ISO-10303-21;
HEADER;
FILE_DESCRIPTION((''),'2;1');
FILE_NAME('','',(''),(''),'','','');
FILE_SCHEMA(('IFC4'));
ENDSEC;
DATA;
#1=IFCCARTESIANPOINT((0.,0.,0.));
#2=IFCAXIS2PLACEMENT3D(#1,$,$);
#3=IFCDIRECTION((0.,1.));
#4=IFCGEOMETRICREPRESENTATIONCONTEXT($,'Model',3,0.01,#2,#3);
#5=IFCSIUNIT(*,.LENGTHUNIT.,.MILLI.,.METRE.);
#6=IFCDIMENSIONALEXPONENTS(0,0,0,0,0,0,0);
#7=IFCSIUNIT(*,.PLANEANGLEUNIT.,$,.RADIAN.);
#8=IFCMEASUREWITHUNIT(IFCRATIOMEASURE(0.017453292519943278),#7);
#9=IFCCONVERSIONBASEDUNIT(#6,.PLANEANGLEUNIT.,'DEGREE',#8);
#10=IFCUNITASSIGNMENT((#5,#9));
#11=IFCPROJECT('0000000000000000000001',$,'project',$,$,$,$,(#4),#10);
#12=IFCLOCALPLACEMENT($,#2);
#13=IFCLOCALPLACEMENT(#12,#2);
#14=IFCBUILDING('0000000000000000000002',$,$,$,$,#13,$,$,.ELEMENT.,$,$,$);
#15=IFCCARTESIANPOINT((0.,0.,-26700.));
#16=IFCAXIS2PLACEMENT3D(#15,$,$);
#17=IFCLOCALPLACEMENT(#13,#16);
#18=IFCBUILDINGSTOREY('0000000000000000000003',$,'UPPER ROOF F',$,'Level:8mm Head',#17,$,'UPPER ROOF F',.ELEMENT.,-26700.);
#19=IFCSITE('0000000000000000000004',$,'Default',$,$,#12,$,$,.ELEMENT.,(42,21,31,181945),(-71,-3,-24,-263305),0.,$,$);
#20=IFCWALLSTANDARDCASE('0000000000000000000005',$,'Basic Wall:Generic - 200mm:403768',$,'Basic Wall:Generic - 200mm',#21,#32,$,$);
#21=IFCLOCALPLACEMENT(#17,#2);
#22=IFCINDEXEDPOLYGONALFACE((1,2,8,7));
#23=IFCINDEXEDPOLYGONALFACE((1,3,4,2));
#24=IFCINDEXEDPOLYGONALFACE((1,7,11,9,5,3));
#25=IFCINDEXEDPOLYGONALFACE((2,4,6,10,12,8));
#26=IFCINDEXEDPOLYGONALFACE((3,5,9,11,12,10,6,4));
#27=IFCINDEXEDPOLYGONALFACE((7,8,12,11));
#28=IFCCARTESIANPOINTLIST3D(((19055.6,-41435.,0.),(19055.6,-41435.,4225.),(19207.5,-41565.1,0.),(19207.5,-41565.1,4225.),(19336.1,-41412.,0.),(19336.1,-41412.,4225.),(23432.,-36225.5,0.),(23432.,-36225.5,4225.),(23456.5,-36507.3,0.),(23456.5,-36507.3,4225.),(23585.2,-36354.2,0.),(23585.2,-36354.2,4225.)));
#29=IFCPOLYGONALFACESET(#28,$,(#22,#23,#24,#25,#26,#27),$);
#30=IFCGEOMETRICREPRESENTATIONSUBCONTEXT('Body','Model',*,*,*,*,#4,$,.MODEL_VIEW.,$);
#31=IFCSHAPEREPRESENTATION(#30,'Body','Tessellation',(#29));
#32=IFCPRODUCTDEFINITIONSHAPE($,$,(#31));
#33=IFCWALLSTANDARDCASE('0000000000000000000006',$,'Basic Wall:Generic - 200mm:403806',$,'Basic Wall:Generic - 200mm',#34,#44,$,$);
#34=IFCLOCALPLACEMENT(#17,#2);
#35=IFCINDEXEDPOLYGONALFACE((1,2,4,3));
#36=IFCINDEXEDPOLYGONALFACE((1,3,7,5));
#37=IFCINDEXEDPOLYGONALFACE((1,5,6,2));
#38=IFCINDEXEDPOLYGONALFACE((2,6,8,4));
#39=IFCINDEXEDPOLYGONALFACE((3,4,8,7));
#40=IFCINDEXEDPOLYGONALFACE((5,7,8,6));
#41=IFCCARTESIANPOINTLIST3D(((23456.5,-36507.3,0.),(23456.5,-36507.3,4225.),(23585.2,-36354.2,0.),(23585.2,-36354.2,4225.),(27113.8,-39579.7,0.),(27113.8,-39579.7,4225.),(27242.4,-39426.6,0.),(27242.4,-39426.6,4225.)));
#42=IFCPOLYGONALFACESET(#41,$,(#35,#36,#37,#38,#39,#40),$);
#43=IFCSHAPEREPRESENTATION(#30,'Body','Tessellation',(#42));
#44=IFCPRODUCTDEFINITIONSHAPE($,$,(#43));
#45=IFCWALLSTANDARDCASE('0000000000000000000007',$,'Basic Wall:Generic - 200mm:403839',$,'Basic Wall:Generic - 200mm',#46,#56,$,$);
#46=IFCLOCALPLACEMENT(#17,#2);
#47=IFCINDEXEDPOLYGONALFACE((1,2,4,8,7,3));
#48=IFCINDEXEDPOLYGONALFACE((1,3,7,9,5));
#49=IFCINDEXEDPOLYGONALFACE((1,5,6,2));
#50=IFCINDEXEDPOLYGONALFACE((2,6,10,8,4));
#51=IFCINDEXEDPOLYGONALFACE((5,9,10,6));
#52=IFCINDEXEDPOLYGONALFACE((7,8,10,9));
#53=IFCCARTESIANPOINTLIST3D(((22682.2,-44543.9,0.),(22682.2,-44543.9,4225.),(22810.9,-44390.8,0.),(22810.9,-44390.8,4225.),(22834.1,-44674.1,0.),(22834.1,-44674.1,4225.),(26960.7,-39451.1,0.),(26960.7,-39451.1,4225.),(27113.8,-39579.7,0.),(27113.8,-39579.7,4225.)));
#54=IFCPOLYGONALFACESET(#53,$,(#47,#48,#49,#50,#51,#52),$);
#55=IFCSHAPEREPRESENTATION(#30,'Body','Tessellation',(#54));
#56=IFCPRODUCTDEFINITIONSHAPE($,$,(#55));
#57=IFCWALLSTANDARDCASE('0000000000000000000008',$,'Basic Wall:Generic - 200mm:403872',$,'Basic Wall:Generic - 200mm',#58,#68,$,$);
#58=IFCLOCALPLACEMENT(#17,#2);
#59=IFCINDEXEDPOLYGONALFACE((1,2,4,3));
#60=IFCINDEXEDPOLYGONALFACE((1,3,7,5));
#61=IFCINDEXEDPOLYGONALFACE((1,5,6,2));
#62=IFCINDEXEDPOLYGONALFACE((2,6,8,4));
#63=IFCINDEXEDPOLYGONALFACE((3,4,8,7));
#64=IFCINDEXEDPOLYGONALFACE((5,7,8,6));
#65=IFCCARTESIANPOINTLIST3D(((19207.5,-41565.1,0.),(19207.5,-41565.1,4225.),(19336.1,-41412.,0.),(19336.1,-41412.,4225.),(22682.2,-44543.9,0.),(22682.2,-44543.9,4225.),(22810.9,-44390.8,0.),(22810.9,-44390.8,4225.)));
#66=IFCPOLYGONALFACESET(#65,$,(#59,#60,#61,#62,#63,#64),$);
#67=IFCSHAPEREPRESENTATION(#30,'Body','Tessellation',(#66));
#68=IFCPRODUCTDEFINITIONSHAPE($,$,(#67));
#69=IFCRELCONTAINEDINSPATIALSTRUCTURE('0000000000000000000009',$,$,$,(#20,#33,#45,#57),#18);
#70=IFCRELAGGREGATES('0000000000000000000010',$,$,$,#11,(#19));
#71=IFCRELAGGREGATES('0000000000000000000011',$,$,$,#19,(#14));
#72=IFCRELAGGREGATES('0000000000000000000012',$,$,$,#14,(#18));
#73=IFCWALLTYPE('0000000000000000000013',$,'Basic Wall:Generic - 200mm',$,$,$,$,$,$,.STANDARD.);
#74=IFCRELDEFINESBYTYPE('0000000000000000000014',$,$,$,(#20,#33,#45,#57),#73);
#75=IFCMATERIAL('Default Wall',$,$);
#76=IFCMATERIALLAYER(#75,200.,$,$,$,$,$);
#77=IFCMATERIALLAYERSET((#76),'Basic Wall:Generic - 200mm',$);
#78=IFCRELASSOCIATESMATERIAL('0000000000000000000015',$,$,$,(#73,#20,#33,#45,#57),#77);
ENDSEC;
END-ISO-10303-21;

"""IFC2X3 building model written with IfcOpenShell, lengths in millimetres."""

from ifc_helpers import new_model, entity, si_unit, converted_unit, direction, frame, frame_2d, origin, place, context, subcontext, project, spatial, polyline, rectangle, outline, extrude, material, layer, layer_set, layer_usage, type_object, element, save


model = new_model("IFC2X3")

# Units and contexts
model_context = context("Model", 3, precision=0.01, world=origin(), true_north=direction((0.0, 1.0)))
body_context = subcontext(model_context, "Body", "Model", "MODEL_VIEW")
ifc_project = project(units=[si_unit("LENGTHUNIT", "METRE", prefix="MILLI"), converted_unit("PLANEANGLEUNIT", "DEGREE", entity("IfcRatioMeasure", 0.017453292519943278), si_unit("PLANEANGLEUNIT", "RADIAN"), dimensions=[0, 0, 0, 0, 0, 0, 0])], contexts=[model_context])

# Site, building, storey
site_placement = place(None, origin())
site = spatial("IfcSite", under=ifc_project, at=site_placement, Name="Default", CompositionType="ELEMENT", RefLatitude=(42, 21, 31, 181945), RefLongitude=(-71, -3, -24, -263305), RefElevation=0.0)
building_placement = place(site_placement, origin())
building = spatial("IfcBuilding", under=site, at=building_placement, CompositionType="ELEMENT")
storey_placement = place(building_placement, frame((0.0, 0.0, -26700.0)))
storey = spatial("IfcBuildingStorey", under=building, at=storey_placement, Name="UPPER ROOF F", ObjectType="Level:8mm Head", LongName="UPPER ROOF F", CompositionType="ELEMENT", Elevation=-26700.0)

# Walls
ifc_material_1 = material(Name="Default Wall")
ifc_layer_1 = layer(ifc_material_1, 200.0)
ifc_layer_set_1 = layer_set([ifc_layer_1], Name="Basic Wall:Generic - 200mm")
ifc_layer_usage_1 = layer_usage(ifc_layer_set_1, "AXIS2", "NEGATIVE", 100.0)
wall_type = type_object("IfcWallType", Name="Basic Wall:Generic - 200mm", PredefinedType="STANDARD", material=ifc_layer_set_1)
wall_1_placement = place(storey_placement, frame((19130.9, -41500.8, 0.0), z_axis=(0.0, 0.0, 1.0), x_axis=(0.64323, 0.765673, 0.0)))
element("IfcWallStandardCase", 1, at=wall_1_placement, inside=storey, type_object=wall_type, material=ifc_layer_usage_1, Name="Basic Wall:Generic - 200mm:403768", ObjectType="Basic Wall:Generic - 200mm", context=body_context, shape_type="SweptSolid", body=[
    extrude(outline(polyline([(6805.7, -100.0), (6805.7, 100.0), (2.0, 100.0), (0.0, -100.0), (200.0, -100.0), (6605.7, -100.0), (6805.7, -100.0)])), origin(), (0.0, 0.0, 1.0), 4225.0),
])
wall_2_placement = place(storey_placement, frame((23520.8, -36430.7, 0.0), z_axis=(0.0, 0.0, 1.0), x_axis=(0.765673, -0.64323, 0.0)))
element("IfcWallStandardCase", 2, at=wall_2_placement, inside=storey, type_object=wall_type, material=ifc_layer_usage_1, Name="Basic Wall:Generic - 200mm:403806", ObjectType="Basic Wall:Generic - 200mm", context=body_context, shape_type="SweptSolid", body=[
    extrude(rectangle(XDim=4776.6, YDim=200.0, at=frame_2d((2388.3, 0.0), x_axis=(-1.0, 0.0))), origin(), (0.0, 0.0, 1.0), 4225.0),
])
wall_3_placement = place(storey_placement, frame((27037.2, -39515.4, 0.0), z_axis=(0.0, 0.0, 1.0), x_axis=(-0.64323, -0.765673, 0.0)))
element("IfcWallStandardCase", 3, at=wall_3_placement, inside=storey, type_object=wall_type, material=ifc_layer_usage_1, Name="Basic Wall:Generic - 200mm:403839", ObjectType="Basic Wall:Generic - 200mm", context=body_context, shape_type="SweptSolid", body=[
    extrude(outline(polyline([(6651.5, -100.0), (6653.5, 100.0), (0.0, 100.0), (0.0, -100.0), (6451.5, -100.0), (6651.5, -100.0)])), origin(), (0.0, 0.0, 1.0), 4225.0),
])
wall_4_placement = place(storey_placement, frame((22747.3, -44468.0, 0.0), z_axis=(0.0, 0.0, 1.0), x_axis=(-0.759205, 0.650852, 0.0)))
element("IfcWallStandardCase", 4, at=wall_4_placement, inside=storey, type_object=wall_type, material=ifc_layer_usage_1, Name="Basic Wall:Generic - 200mm:403872", ObjectType="Basic Wall:Generic - 200mm", context=body_context, shape_type="SweptSolid", body=[
    extrude(outline(polyline([(4578.8, -100.0), (4576.8, 100.0), (0.0, 100.0), (2.0, -100.0), (4578.8, -100.0)])), origin(), (0.0, 0.0, 1.0), 4225.0),
])

save(model, "model.ifc")
